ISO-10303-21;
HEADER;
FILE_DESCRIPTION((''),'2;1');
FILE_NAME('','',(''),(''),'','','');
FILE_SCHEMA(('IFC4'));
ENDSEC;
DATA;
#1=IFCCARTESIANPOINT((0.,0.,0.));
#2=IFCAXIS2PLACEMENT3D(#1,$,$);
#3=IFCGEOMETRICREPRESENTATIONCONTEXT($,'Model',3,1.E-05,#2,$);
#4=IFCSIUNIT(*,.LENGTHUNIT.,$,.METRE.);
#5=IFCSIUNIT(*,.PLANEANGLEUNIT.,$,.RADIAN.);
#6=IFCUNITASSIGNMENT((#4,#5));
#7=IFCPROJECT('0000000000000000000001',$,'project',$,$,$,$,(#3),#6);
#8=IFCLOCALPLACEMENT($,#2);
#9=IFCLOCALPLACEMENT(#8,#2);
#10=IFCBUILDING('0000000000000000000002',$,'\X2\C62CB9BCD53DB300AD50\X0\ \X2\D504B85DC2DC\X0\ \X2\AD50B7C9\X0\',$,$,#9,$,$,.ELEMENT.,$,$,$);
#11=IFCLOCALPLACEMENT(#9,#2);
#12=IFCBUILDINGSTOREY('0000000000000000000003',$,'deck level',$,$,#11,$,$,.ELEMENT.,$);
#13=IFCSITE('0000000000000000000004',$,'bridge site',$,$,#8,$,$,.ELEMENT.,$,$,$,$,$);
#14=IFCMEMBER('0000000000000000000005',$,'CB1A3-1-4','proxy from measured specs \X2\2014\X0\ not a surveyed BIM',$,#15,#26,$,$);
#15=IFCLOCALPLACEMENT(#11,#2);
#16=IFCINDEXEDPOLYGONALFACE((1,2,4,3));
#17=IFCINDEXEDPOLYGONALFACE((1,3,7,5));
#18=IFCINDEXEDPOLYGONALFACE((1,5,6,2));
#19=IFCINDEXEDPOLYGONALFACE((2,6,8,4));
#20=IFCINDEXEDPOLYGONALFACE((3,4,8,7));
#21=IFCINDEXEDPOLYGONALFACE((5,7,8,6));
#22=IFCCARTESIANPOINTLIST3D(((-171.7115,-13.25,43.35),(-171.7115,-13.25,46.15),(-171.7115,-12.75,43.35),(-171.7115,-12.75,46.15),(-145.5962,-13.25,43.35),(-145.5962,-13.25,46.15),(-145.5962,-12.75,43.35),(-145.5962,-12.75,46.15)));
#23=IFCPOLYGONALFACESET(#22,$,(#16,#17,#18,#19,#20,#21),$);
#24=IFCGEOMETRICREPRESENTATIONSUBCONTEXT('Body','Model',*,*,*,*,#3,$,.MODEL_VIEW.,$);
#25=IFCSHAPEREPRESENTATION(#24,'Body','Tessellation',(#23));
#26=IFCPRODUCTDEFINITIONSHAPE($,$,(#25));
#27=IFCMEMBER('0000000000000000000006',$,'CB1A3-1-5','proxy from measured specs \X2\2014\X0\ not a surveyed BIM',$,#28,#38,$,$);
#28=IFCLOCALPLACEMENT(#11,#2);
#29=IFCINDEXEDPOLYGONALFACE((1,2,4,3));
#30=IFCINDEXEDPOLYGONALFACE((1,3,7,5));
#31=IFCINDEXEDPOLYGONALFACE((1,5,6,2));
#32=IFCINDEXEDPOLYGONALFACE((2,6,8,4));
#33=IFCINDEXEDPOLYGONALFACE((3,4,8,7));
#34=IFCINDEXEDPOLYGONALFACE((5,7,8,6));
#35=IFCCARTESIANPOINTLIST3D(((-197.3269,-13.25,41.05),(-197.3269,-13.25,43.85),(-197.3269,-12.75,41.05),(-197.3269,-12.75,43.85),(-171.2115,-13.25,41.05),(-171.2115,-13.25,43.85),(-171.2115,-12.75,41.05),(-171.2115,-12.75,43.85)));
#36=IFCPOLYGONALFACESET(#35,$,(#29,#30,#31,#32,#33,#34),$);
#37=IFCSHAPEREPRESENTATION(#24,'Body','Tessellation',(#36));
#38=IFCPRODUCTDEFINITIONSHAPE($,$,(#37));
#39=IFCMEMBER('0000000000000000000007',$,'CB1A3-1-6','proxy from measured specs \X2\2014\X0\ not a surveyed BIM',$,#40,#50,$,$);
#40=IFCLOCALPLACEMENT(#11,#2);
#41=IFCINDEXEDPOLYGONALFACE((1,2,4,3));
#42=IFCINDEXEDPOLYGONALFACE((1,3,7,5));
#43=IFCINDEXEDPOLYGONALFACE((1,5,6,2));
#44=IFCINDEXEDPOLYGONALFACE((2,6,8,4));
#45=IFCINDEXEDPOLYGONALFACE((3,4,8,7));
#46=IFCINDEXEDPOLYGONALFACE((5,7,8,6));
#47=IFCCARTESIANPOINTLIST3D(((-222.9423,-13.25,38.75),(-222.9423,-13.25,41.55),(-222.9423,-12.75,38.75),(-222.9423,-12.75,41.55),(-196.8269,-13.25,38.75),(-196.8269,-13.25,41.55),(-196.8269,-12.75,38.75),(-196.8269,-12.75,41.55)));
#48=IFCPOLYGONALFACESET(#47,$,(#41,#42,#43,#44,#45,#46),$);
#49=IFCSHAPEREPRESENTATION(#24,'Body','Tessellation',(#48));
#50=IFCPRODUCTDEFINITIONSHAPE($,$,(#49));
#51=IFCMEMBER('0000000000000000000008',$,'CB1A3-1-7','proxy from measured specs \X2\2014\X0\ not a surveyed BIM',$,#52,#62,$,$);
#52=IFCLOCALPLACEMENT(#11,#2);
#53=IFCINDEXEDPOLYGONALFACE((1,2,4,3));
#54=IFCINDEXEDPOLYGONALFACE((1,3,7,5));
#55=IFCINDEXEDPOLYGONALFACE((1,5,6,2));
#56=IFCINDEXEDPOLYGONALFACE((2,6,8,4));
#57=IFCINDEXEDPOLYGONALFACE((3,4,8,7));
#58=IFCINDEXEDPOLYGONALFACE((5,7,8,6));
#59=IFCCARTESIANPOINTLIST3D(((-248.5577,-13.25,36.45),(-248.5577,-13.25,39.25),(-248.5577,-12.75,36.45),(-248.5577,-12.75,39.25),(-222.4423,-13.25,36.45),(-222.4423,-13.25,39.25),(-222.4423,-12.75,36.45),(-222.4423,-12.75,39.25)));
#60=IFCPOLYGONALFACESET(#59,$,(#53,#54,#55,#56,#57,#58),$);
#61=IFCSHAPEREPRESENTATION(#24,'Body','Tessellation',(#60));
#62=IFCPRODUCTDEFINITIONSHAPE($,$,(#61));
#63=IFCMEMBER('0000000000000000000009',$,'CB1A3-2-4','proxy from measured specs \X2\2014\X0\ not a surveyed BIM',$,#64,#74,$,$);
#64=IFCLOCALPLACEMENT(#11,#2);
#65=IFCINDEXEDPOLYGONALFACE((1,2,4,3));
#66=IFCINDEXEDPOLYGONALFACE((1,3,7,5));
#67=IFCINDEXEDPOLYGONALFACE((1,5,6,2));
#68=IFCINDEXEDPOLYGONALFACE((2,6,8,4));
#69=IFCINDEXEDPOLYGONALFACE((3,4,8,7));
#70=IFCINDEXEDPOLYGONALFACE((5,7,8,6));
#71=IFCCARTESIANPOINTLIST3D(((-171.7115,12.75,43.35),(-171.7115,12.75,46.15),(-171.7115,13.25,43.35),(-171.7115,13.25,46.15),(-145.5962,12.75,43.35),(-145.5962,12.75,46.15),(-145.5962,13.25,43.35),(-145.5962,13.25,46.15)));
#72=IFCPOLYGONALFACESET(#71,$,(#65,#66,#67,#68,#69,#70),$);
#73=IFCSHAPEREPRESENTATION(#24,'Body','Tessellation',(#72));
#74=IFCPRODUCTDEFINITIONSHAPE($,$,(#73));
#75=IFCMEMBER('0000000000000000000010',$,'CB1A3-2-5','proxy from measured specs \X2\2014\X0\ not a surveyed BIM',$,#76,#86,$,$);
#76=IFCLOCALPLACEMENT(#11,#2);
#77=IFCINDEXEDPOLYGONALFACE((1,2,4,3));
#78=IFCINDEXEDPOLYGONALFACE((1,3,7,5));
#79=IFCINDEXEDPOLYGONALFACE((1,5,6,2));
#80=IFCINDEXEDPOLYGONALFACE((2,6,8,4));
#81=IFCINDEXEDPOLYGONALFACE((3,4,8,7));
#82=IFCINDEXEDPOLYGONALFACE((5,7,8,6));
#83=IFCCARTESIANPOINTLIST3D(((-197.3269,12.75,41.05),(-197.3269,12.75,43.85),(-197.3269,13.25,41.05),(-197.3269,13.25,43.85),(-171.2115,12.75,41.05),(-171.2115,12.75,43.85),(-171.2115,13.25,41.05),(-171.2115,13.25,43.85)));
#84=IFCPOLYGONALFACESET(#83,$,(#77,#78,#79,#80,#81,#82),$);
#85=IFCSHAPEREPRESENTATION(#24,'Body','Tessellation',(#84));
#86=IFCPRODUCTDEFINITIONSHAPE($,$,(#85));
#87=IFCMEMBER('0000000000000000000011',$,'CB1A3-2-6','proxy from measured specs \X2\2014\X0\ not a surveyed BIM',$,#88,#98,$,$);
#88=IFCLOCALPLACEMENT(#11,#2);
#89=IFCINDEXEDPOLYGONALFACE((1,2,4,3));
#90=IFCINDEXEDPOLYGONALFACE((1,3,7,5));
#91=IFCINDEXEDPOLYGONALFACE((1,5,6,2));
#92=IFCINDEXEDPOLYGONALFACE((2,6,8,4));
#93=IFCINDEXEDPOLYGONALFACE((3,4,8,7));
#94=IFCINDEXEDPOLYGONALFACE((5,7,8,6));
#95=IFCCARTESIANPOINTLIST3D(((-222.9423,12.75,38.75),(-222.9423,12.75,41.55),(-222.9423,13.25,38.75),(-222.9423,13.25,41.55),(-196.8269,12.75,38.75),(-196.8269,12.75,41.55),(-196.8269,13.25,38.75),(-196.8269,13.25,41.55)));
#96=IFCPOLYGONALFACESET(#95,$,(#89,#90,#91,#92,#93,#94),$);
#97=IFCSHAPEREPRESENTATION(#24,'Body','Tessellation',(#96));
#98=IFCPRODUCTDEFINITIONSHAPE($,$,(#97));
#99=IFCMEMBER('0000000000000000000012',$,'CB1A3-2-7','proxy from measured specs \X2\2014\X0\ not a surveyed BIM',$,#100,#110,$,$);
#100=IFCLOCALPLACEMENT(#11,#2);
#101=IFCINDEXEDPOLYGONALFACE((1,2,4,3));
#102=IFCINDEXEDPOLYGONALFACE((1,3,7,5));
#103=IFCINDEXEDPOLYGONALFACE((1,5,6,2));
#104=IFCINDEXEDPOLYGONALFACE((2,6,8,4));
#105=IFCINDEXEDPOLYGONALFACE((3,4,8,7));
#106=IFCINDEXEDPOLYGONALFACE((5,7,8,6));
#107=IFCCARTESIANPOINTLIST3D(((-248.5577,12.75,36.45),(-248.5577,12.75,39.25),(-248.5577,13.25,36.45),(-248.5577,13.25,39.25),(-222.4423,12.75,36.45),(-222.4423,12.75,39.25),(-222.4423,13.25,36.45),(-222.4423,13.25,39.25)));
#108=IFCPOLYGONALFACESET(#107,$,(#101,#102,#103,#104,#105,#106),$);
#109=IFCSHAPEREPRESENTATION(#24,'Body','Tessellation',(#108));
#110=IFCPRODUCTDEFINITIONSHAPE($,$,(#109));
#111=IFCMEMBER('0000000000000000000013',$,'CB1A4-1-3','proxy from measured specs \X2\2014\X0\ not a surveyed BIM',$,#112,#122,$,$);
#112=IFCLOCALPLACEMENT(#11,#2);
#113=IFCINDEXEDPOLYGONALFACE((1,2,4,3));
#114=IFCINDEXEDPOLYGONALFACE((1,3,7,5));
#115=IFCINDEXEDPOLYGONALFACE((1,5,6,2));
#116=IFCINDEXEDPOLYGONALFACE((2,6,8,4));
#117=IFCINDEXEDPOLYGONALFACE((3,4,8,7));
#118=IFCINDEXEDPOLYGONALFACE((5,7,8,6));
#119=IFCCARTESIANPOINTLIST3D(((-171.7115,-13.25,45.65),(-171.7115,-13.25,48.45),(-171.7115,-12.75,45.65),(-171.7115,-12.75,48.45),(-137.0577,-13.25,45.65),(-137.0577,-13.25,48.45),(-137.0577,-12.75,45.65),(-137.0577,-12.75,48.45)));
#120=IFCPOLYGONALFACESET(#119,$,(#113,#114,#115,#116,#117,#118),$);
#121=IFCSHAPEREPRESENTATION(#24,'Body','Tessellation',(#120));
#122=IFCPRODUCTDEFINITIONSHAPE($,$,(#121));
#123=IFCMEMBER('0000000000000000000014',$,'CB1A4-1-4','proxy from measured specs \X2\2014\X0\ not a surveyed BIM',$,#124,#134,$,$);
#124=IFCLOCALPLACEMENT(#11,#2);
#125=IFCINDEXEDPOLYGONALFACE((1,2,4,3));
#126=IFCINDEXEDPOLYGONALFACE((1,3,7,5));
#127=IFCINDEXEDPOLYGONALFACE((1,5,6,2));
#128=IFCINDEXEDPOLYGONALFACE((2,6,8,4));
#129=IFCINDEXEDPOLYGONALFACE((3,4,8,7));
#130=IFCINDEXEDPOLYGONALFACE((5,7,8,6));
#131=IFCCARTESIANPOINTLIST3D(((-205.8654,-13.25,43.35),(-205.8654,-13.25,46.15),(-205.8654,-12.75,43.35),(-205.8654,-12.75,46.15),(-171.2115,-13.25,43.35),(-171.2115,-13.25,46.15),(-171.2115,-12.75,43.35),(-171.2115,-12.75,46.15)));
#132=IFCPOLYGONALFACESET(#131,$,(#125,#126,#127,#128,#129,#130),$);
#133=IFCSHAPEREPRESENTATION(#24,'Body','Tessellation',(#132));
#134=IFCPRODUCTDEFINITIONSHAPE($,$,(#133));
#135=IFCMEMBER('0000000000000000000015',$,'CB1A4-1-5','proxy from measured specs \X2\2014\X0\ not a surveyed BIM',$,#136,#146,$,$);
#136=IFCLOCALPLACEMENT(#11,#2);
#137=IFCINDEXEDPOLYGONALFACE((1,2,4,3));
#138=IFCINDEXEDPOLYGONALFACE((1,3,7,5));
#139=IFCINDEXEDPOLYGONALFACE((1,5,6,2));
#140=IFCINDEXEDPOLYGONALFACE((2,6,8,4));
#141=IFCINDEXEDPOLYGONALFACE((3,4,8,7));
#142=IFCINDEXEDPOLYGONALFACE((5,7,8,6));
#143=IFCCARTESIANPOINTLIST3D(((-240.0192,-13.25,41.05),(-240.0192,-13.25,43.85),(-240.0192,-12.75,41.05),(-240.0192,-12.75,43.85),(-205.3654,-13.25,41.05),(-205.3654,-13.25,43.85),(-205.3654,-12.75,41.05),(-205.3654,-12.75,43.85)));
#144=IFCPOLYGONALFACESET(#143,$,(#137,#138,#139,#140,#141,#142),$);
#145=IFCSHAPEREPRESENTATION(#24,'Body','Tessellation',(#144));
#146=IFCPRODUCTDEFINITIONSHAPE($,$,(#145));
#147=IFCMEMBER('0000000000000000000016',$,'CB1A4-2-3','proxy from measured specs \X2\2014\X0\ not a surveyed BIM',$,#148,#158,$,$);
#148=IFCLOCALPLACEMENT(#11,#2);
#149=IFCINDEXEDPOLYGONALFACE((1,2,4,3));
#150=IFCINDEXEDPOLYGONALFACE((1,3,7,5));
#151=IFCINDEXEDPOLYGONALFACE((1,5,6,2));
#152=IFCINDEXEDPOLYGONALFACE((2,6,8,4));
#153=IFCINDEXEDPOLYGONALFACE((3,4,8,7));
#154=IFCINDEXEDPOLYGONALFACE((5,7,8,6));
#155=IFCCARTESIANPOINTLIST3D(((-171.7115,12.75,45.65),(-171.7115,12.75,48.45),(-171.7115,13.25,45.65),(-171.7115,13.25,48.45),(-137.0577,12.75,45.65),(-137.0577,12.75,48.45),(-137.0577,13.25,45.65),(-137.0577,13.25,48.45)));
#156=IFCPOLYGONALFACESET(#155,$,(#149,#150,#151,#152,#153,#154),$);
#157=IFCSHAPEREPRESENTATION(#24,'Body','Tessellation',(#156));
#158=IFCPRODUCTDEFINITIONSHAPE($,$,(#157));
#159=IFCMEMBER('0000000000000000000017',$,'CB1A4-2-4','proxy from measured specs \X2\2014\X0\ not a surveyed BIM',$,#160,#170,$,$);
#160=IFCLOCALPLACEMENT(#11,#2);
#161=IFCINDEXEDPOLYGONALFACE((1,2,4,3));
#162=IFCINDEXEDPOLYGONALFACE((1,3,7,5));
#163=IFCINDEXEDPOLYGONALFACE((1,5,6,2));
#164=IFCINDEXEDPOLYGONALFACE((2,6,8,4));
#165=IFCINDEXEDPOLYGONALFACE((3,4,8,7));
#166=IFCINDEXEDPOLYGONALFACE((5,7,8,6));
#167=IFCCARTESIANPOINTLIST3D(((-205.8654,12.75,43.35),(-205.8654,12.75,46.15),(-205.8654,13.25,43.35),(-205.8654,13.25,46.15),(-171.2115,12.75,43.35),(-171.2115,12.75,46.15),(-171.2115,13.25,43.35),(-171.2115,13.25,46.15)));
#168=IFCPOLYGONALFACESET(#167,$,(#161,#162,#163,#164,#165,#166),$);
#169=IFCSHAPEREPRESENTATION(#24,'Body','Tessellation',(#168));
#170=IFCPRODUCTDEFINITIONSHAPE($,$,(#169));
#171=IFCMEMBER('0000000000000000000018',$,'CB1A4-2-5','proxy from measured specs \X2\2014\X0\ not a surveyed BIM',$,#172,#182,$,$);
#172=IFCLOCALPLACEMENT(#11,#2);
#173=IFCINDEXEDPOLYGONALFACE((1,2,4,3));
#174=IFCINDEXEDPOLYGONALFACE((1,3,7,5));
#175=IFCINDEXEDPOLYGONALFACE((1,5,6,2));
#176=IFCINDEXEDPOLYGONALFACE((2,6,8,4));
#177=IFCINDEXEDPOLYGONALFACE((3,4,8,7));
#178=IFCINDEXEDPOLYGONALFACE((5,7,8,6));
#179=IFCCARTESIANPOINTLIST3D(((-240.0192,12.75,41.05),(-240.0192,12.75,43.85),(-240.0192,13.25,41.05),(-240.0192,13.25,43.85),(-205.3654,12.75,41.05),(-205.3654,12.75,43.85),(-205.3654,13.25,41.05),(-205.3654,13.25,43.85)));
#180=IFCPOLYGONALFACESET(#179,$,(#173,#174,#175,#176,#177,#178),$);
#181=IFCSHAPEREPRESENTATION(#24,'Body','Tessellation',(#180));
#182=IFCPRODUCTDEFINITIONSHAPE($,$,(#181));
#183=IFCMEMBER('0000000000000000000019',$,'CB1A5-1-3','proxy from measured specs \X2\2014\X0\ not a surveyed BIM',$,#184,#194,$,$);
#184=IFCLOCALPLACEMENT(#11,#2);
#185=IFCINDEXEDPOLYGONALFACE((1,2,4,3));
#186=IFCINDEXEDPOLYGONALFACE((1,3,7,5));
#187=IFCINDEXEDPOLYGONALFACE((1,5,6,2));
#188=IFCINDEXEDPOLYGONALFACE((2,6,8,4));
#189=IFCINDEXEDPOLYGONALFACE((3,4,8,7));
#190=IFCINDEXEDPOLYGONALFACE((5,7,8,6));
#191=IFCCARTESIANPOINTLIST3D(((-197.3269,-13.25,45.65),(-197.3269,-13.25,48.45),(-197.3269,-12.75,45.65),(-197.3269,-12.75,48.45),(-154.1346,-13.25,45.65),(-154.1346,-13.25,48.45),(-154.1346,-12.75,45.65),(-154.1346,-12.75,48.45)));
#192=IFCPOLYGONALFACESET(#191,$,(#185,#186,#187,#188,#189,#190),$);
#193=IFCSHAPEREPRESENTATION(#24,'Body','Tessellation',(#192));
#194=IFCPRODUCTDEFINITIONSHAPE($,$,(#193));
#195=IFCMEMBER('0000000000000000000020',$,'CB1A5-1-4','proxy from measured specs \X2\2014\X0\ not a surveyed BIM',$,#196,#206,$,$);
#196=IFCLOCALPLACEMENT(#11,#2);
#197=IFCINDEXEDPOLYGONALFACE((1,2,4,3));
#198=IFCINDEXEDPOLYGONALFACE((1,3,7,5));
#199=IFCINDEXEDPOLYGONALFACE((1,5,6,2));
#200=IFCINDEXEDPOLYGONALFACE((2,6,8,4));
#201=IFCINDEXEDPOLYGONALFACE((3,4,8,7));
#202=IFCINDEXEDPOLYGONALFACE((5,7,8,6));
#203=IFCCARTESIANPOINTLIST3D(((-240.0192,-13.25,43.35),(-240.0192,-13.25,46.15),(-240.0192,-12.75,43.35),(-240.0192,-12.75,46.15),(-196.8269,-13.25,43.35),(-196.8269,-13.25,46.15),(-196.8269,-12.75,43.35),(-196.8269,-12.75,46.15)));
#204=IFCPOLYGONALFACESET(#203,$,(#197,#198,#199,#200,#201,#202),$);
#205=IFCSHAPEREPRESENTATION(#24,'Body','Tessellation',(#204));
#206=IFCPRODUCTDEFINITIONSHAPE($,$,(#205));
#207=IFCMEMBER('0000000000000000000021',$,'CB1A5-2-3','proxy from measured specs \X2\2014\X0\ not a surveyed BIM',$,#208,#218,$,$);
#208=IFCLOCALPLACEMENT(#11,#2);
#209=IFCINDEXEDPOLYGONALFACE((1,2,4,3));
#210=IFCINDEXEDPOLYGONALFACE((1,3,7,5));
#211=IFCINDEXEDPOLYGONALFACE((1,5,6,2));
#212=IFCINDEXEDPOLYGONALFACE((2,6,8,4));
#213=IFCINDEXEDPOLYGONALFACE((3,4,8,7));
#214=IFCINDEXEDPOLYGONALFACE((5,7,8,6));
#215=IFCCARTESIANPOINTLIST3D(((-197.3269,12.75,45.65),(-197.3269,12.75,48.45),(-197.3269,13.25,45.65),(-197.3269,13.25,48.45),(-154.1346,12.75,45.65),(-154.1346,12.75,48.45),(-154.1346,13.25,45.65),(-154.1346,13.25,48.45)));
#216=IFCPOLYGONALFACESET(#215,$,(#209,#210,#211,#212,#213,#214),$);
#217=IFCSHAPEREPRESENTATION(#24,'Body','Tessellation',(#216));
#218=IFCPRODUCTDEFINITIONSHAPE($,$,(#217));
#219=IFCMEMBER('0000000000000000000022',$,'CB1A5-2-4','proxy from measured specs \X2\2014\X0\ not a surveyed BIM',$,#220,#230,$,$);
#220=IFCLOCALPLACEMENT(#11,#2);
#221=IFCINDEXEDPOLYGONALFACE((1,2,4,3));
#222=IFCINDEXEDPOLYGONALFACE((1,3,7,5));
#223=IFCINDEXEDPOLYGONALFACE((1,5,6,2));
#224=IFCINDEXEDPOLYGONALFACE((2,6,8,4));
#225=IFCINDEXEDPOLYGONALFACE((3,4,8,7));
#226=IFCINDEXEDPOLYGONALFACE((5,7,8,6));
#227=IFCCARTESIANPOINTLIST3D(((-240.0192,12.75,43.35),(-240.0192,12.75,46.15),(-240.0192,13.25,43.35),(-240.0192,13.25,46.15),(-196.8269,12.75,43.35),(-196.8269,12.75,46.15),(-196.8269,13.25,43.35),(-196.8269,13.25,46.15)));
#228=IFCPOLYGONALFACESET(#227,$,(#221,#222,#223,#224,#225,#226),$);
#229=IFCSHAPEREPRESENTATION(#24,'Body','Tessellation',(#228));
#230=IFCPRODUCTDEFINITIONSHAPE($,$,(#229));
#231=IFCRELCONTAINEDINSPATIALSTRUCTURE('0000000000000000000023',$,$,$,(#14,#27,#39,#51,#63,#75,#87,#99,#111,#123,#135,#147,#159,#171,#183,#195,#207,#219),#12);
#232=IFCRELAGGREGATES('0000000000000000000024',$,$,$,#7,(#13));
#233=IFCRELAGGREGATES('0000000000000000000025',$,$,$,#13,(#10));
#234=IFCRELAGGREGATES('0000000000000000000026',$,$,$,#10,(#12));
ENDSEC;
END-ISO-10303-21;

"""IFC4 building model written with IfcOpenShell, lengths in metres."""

from ifc_helpers import new_model, si_unit, frame, origin, origin_2d, place, context, subcontext, project, spatial, rectangle, extrude, element, save


model = new_model("IFC4")

# Units and contexts
model_context = context("Model", 3, precision=1e-05, world=origin())
body_context = subcontext(model_context, "Body", "Model", "MODEL_VIEW")
ifc_project = project(units=[si_unit("LENGTHUNIT", "METRE"), si_unit("PLANEANGLEUNIT", "RADIAN")], contexts=[model_context])

# Site, building, storey
site_placement = place(None, origin())
site = spatial("IfcSite", under=ifc_project, at=site_placement, Name="bridge site", CompositionType="ELEMENT")
building_placement = place(site_placement, origin())
building = spatial("IfcBuilding", under=site, at=building_placement, Name="올림픽대교 프록시 교량", CompositionType="ELEMENT")
storey_placement = place(building_placement, origin())
storey = spatial("IfcBuildingStorey", under=building, at=storey_placement, Name="deck level", CompositionType="ELEMENT")

# Members
member_1_placement = place(storey_placement, frame((-158.6538, -13.0, 43.35)))
element("IfcMember", 1, at=member_1_placement, inside=storey, Name="CB1A3-1-4", Description="proxy from measured specs — not a surveyed BIM", context=body_context, shape_type="SweptSolid", body=[
    extrude(rectangle(XDim=26.1154, YDim=0.5, at=origin_2d()), origin(), (0.0, 0.0, 1.0), 2.8),
])
for number, where, name in (
    (2, (-184.2692, -13.0, 41.05), "CB1A3-1-5"),
    (3, (-209.8846, -13.0, 38.75), "CB1A3-1-6"),
    (4, (-235.5, -13.0, 36.45), "CB1A3-1-7"),
):
    element("IfcMember", number, at=place(storey_placement, frame(where)), inside=storey, Name=name, Description="proxy from measured specs — not a surveyed BIM", context=body_context, shape_type="SweptSolid", body=[
        extrude(rectangle(XDim=26.1154, YDim=0.5, at=origin_2d()), origin(), (0.0, 0.0, 1.0), 2.8),
    ])
member_2_placement = place(storey_placement, frame((-158.6538, 13.0, 43.35)))
element("IfcMember", 5, at=member_2_placement, inside=storey, Name="CB1A3-2-4", Description="proxy from measured specs — not a surveyed BIM", context=body_context, shape_type="SweptSolid", body=[
    extrude(rectangle(XDim=26.1154, YDim=0.5, at=origin_2d()), origin(), (0.0, 0.0, 1.0), 2.8),
])
for number, where, name in (
    (6, (-184.2692, 13.0, 41.05), "CB1A3-2-5"),
    (7, (-209.8846, 13.0, 38.75), "CB1A3-2-6"),
    (8, (-235.5, 13.0, 36.45), "CB1A3-2-7"),
):
    element("IfcMember", number, at=place(storey_placement, frame(where)), inside=storey, Name=name, Description="proxy from measured specs — not a surveyed BIM", context=body_context, shape_type="SweptSolid", body=[
        extrude(rectangle(XDim=26.1154, YDim=0.5, at=origin_2d()), origin(), (0.0, 0.0, 1.0), 2.8),
    ])
member_3_placement = place(storey_placement, frame((-154.3846, -13.0, 45.65)))
element("IfcMember", 9, at=member_3_placement, inside=storey, Name="CB1A4-1-3", Description="proxy from measured specs — not a surveyed BIM", context=body_context, shape_type="SweptSolid", body=[
    extrude(rectangle(XDim=34.6538, YDim=0.5, at=origin_2d()), origin(), (0.0, 0.0, 1.0), 2.8),
])
member_4_placement = place(storey_placement, frame((-188.5385, -13.0, 43.35)))
element("IfcMember", 10, at=member_4_placement, inside=storey, Name="CB1A4-1-4", Description="proxy from measured specs — not a surveyed BIM", context=body_context, shape_type="SweptSolid", body=[
    extrude(rectangle(XDim=34.6538, YDim=0.5, at=origin_2d()), origin(), (0.0, 0.0, 1.0), 2.8),
])
member_5_placement = place(storey_placement, frame((-222.6923, -13.0, 41.05)))
element("IfcMember", 11, at=member_5_placement, inside=storey, Name="CB1A4-1-5", Description="proxy from measured specs — not a surveyed BIM", context=body_context, shape_type="SweptSolid", body=[
    extrude(rectangle(XDim=34.6538, YDim=0.5, at=origin_2d()), origin(), (0.0, 0.0, 1.0), 2.8),
])
member_6_placement = place(storey_placement, frame((-154.3846, 13.0, 45.65)))
element("IfcMember", 12, at=member_6_placement, inside=storey, Name="CB1A4-2-3", Description="proxy from measured specs — not a surveyed BIM", context=body_context, shape_type="SweptSolid", body=[
    extrude(rectangle(XDim=34.6538, YDim=0.5, at=origin_2d()), origin(), (0.0, 0.0, 1.0), 2.8),
])
member_7_placement = place(storey_placement, frame((-188.5385, 13.0, 43.35)))
element("IfcMember", 13, at=member_7_placement, inside=storey, Name="CB1A4-2-4", Description="proxy from measured specs — not a surveyed BIM", context=body_context, shape_type="SweptSolid", body=[
    extrude(rectangle(XDim=34.6538, YDim=0.5, at=origin_2d()), origin(), (0.0, 0.0, 1.0), 2.8),
])
member_8_placement = place(storey_placement, frame((-222.6923, 13.0, 41.05)))
element("IfcMember", 14, at=member_8_placement, inside=storey, Name="CB1A4-2-5", Description="proxy from measured specs — not a surveyed BIM", context=body_context, shape_type="SweptSolid", body=[
    extrude(rectangle(XDim=34.6538, YDim=0.5, at=origin_2d()), origin(), (0.0, 0.0, 1.0), 2.8),
])
member_9_placement = place(storey_placement, frame((-175.7308, -13.0, 45.65)))
element("IfcMember", 15, at=member_9_placement, inside=storey, Name="CB1A5-1-3", Description="proxy from measured specs — not a surveyed BIM", context=body_context, shape_type="SweptSolid", body=[
    extrude(rectangle(XDim=43.1923, YDim=0.5, at=origin_2d()), origin(), (0.0, 0.0, 1.0), 2.8),
])
member_10_placement = place(storey_placement, frame((-218.4231, -13.0, 43.35)))
element("IfcMember", 16, at=member_10_placement, inside=storey, Name="CB1A5-1-4", Description="proxy from measured specs — not a surveyed BIM", context=body_context, shape_type="SweptSolid", body=[
    extrude(rectangle(XDim=43.1923, YDim=0.5, at=origin_2d()), origin(), (0.0, 0.0, 1.0), 2.8),
])
member_11_placement = place(storey_placement, frame((-175.7308, 13.0, 45.65)))
element("IfcMember", 17, at=member_11_placement, inside=storey, Name="CB1A5-2-3", Description="proxy from measured specs — not a surveyed BIM", context=body_context, shape_type="SweptSolid", body=[
    extrude(rectangle(XDim=43.1923, YDim=0.5, at=origin_2d()), origin(), (0.0, 0.0, 1.0), 2.8),
])
member_12_placement = place(storey_placement, frame((-218.4231, 13.0, 43.35)))
element("IfcMember", 18, at=member_12_placement, inside=storey, Name="CB1A5-2-4", Description="proxy from measured specs — not a surveyed BIM", context=body_context, shape_type="SweptSolid", body=[
    extrude(rectangle(XDim=43.1923, YDim=0.5, at=origin_2d()), origin(), (0.0, 0.0, 1.0), 2.8),
])

save(model, "model.ifc")
